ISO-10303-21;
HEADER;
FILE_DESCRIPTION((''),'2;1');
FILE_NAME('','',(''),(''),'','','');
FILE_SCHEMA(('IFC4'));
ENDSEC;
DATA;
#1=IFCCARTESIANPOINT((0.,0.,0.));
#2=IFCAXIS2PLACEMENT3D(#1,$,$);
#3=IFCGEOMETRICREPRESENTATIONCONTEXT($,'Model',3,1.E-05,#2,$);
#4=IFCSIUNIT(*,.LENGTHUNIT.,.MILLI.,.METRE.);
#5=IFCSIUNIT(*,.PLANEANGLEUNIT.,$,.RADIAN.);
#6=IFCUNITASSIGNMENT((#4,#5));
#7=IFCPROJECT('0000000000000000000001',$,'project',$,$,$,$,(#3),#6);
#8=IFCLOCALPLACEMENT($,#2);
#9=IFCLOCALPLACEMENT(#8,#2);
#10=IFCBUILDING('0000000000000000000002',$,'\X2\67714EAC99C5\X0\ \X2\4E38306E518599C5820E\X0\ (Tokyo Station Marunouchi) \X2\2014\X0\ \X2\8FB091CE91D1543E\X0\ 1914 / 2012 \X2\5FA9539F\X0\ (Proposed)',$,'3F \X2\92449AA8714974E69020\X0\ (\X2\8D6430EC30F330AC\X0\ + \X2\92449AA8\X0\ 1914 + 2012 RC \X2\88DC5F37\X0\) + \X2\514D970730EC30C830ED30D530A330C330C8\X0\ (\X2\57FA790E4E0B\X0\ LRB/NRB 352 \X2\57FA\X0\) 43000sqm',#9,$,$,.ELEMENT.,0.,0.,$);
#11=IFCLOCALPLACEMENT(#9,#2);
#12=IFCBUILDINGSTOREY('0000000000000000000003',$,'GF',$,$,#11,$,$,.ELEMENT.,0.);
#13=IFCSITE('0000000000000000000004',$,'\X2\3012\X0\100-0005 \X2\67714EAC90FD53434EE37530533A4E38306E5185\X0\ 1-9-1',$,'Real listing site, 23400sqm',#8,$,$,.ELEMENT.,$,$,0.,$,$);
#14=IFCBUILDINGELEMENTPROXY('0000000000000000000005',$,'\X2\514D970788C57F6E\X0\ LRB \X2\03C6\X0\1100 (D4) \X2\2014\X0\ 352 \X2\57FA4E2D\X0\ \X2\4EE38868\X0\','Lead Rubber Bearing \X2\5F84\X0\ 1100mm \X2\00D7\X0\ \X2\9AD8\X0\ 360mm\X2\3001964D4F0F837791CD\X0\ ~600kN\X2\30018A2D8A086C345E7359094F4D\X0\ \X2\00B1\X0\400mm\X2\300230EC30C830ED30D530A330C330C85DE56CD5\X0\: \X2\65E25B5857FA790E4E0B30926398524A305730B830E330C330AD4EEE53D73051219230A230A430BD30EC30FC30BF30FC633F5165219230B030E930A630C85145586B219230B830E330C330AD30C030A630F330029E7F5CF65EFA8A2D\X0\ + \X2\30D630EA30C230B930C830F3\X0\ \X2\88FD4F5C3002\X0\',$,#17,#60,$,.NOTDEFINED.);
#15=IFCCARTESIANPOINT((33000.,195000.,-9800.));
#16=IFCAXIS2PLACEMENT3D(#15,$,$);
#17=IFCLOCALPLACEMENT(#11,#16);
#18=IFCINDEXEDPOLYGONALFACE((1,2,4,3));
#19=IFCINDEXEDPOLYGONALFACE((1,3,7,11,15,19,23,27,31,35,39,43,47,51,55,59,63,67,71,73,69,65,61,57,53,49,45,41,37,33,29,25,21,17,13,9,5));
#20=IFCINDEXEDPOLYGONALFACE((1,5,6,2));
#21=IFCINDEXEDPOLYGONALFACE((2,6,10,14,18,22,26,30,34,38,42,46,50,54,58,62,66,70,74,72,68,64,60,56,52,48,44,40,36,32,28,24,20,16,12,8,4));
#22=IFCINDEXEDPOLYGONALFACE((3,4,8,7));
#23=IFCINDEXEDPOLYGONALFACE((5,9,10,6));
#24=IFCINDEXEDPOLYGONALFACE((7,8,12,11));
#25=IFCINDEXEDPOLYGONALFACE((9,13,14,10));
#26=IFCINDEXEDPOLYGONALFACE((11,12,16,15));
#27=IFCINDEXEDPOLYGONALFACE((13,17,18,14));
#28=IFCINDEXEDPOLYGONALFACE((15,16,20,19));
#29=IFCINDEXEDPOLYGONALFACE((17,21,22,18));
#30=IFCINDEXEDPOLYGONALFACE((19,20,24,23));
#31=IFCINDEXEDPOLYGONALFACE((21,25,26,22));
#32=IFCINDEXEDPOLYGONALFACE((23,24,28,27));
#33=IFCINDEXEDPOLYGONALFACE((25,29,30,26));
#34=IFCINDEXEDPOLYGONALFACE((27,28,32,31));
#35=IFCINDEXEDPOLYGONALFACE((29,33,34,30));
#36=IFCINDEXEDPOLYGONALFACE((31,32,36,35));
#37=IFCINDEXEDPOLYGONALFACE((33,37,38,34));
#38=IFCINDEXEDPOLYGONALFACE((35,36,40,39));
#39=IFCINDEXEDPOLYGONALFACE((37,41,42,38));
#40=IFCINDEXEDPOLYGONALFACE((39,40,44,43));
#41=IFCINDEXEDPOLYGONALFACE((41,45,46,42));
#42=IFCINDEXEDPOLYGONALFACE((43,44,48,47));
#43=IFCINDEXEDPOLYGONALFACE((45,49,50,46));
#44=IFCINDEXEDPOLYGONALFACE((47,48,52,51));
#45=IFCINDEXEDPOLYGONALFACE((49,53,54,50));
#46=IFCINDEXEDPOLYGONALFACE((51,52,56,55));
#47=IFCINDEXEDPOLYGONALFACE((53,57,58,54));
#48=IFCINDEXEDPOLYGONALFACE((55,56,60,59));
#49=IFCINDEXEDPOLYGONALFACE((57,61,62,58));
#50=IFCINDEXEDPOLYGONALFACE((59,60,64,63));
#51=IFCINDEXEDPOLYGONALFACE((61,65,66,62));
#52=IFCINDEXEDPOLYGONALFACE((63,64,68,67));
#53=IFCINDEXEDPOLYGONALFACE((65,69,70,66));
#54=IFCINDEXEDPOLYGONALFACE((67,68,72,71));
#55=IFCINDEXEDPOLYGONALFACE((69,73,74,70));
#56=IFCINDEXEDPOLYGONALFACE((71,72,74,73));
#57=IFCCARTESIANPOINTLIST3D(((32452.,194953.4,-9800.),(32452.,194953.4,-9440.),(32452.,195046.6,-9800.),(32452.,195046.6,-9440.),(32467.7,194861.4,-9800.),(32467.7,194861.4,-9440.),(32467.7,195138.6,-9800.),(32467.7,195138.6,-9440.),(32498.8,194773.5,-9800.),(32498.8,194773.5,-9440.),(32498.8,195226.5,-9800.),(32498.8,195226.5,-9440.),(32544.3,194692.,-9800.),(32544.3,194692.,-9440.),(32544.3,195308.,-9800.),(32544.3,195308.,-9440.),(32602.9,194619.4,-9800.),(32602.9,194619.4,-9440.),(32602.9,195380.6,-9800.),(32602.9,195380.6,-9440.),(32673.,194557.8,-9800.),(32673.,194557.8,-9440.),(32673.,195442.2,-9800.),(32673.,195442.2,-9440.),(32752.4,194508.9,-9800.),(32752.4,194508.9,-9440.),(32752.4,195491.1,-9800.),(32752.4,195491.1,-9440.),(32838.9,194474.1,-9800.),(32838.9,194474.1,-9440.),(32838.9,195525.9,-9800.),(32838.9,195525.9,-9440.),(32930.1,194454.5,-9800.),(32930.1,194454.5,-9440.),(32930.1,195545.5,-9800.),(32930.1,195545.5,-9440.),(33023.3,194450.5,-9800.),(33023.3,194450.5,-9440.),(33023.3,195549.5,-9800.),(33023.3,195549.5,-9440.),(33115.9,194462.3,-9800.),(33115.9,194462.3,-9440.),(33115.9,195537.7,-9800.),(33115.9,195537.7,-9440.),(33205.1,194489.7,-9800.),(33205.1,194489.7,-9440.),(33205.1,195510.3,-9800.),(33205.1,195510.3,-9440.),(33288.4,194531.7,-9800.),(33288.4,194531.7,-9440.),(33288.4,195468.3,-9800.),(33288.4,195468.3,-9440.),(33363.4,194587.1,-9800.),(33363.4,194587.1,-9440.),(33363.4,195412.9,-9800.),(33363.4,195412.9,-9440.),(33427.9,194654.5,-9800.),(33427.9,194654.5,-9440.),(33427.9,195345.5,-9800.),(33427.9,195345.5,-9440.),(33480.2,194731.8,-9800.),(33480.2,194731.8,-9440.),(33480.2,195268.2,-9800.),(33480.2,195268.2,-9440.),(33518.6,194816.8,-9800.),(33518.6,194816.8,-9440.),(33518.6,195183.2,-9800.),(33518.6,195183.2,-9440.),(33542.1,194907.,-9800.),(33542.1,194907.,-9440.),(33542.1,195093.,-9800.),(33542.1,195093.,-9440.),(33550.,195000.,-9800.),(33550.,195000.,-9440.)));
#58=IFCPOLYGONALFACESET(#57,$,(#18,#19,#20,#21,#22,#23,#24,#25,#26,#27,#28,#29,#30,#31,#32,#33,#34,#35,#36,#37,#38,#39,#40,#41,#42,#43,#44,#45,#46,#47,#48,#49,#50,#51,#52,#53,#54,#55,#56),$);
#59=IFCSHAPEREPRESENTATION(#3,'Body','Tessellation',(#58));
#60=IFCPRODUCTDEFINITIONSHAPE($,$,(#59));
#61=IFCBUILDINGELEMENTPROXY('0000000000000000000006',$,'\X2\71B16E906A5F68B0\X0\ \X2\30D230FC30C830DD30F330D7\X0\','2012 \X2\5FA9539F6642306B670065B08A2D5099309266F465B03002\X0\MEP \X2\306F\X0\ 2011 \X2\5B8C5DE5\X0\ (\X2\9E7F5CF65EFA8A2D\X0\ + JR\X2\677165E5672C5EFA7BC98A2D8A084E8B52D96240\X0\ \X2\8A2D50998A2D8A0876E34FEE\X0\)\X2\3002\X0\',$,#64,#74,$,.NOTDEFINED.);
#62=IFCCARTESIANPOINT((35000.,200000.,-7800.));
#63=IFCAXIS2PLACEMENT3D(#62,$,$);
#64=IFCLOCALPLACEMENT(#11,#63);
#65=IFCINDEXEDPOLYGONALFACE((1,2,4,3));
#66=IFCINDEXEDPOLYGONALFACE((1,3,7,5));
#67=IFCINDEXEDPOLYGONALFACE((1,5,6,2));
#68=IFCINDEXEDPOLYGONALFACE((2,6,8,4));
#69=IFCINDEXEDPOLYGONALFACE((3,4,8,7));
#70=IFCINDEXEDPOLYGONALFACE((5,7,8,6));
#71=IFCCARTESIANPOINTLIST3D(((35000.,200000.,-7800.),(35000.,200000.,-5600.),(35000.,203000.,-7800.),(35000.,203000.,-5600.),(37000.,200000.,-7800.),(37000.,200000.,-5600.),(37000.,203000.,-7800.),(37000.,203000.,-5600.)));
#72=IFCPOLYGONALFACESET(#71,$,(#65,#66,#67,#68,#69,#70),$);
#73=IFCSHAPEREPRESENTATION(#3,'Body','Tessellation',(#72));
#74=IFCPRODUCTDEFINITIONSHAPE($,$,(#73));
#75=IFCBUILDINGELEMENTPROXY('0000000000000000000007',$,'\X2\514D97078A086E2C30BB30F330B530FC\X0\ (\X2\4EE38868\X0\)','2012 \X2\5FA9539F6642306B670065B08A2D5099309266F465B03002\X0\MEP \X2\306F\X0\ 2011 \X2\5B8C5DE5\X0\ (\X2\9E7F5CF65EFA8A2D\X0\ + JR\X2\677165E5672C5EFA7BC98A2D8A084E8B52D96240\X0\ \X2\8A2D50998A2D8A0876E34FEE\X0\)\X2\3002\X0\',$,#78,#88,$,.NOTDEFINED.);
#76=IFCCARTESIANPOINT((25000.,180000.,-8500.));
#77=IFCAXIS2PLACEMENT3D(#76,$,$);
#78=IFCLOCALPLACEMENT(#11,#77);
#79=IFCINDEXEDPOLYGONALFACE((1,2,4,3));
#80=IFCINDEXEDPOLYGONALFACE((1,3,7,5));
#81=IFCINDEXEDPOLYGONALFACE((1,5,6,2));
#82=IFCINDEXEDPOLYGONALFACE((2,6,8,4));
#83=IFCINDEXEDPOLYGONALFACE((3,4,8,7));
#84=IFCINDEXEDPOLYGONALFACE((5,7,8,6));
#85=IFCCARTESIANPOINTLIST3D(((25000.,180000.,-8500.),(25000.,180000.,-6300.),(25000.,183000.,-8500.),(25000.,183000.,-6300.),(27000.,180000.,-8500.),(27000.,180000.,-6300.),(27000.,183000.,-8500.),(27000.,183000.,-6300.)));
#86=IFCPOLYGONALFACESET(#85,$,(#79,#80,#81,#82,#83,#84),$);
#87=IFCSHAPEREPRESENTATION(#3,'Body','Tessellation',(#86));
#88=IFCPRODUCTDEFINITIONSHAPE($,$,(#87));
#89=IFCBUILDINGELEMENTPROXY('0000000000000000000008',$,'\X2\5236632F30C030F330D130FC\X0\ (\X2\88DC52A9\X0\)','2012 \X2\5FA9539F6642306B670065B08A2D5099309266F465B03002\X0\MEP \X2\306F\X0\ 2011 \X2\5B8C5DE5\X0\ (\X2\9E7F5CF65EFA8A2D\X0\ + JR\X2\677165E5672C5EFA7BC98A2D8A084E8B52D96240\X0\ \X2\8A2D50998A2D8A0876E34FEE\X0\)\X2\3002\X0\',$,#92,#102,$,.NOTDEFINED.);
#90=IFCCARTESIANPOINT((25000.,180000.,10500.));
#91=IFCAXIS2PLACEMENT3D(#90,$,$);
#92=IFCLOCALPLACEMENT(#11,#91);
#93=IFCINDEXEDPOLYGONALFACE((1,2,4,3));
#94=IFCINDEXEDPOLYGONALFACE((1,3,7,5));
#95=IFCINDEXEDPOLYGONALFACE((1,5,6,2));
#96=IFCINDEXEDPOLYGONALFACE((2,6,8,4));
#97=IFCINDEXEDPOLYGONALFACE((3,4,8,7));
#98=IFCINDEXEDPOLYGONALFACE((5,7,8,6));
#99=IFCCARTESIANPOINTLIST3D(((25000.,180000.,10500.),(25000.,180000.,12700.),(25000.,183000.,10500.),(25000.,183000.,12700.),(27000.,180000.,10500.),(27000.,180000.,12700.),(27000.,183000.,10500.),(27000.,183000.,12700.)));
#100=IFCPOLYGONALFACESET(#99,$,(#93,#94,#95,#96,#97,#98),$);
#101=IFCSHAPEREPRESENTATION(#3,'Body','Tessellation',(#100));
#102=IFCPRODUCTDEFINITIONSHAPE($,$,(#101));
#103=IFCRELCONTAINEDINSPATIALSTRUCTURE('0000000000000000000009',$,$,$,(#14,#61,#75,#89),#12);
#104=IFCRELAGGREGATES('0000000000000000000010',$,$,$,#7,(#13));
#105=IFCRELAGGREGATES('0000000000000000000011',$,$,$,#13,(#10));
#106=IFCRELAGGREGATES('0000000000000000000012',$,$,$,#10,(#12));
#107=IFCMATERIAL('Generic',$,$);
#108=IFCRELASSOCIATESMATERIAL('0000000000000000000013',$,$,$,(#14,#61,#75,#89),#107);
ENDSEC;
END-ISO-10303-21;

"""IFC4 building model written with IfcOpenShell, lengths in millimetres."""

from ifc_helpers import new_model, si_unit, frame, frame_2d, origin, origin_2d, place, context, project, spatial, rectangle, circle, extrude, material, element, save


model = new_model("IFC4")

# Units and contexts
model_context = context("Model", 3, precision=1e-05, world=origin())
ifc_project = project(units=[si_unit("LENGTHUNIT", "METRE", prefix="MILLI"), si_unit("PLANEANGLEUNIT", "RADIAN")], contexts=[model_context])

# Site, building, storey
site_placement = place(None, origin())
site = spatial("IfcSite", under=ifc_project, at=site_placement, Name="〒100-0005 東京都千代田区丸の内 1-9-1", ObjectType="Real listing site, 23400sqm", CompositionType="ELEMENT", RefElevation=0.0)
building_placement = place(site_placement, origin())
building = spatial("IfcBuilding", under=site, at=building_placement, Name="東京駅 丸の内駅舎 (Tokyo Station Marunouchi) — 辰野金吾 1914 / 2012 復原 (Proposed)", ObjectType="3F 鉄骨煉瓦造 (赤レンガ + 鉄骨 1914 + 2012 RC 補強) + 免震レトロフィット (基礎下 LRB/NRB 352 基) 43000sqm", CompositionType="ELEMENT", ElevationOfRefHeight=0.0, ElevationOfTerrain=0.0)
storey_placement = place(building_placement, origin())
storey = spatial("IfcBuildingStorey", under=building, at=storey_placement, Name="GF", CompositionType="ELEMENT", Elevation=0.0)

# Shared definitions
ifc_material_1 = material(Name="Generic")

# Building element proxies
proxy_1_placement = place(storey_placement, frame((33000.0, 195000.0, -9800.0)))
element("IfcBuildingElementProxy", 1, at=proxy_1_placement, inside=storey, material=ifc_material_1, Name="免震装置 LRB φ1100 (D4) — 352 基中 代表", Description="Lead Rubber Bearing 径 1100mm × 高 360mm、降伏荷重 ~600kN、設計水平変位 ±400mm。レトロフィット工法: 既存基礎下を掘削しジャッキ仮受け→アイソレーター挿入→グラウト充填→ジャッキダウン。鹿島建設 + ブリヂストン 製作。", PredefinedType="NOTDEFINED", context=model_context, shape_type="SweptSolid", body=[
    extrude(circle(Radius=550.0, at=origin_2d()), frame((33000.0, 195000.0, -9800.0)), (0.0, 0.0, 1.0), 360.0),
])
proxy_2_placement = place(storey_placement, frame((35000.0, 200000.0, -7800.0)))
element("IfcBuildingElementProxy", 2, at=proxy_2_placement, inside=storey, material=ifc_material_1, Name="熱源機械 ヒートポンプ", Description="2012 復原時に最新設備を更新。MEP は 2011 完工 (鹿島建設 + JR東日本建築設計事務所 設備設計監修)。", PredefinedType="NOTDEFINED", context=model_context, shape_type="SweptSolid", body=[
    extrude(rectangle(XDim=2000.0, YDim=3000.0, at=frame_2d((1000.0, 1500.0))), frame((35000.0, 200000.0, -7800.0)), (0.0, 0.0, 1.0), 2200.0),
])
proxy_3_placement = place(storey_placement, frame((25000.0, 180000.0, -8500.0)))
element("IfcBuildingElementProxy", 3, at=proxy_3_placement, inside=storey, material=ifc_material_1, Name="免震計測センサー (代表)", Description="2012 復原時に最新設備を更新。MEP は 2011 完工 (鹿島建設 + JR東日本建築設計事務所 設備設計監修)。", PredefinedType="NOTDEFINED", context=model_context, shape_type="SweptSolid", body=[
    extrude(rectangle(XDim=2000.0, YDim=3000.0, at=frame_2d((1000.0, 1500.0))), frame((25000.0, 180000.0, -8500.0)), (0.0, 0.0, 1.0), 2200.0),
])
proxy_4_placement = place(storey_placement, frame((25000.0, 180000.0, 10500.0)))
element("IfcBuildingElementProxy", 4, at=proxy_4_placement, inside=storey, material=ifc_material_1, Name="制振ダンパー (補助)", Description="2012 復原時に最新設備を更新。MEP は 2011 完工 (鹿島建設 + JR東日本建築設計事務所 設備設計監修)。", PredefinedType="NOTDEFINED", context=model_context, shape_type="SweptSolid", body=[
    extrude(rectangle(XDim=2000.0, YDim=3000.0, at=frame_2d((1000.0, 1500.0))), frame((25000.0, 180000.0, 10500.0)), (0.0, 0.0, 1.0), 2200.0),
])

save(model, "model.ifc")
